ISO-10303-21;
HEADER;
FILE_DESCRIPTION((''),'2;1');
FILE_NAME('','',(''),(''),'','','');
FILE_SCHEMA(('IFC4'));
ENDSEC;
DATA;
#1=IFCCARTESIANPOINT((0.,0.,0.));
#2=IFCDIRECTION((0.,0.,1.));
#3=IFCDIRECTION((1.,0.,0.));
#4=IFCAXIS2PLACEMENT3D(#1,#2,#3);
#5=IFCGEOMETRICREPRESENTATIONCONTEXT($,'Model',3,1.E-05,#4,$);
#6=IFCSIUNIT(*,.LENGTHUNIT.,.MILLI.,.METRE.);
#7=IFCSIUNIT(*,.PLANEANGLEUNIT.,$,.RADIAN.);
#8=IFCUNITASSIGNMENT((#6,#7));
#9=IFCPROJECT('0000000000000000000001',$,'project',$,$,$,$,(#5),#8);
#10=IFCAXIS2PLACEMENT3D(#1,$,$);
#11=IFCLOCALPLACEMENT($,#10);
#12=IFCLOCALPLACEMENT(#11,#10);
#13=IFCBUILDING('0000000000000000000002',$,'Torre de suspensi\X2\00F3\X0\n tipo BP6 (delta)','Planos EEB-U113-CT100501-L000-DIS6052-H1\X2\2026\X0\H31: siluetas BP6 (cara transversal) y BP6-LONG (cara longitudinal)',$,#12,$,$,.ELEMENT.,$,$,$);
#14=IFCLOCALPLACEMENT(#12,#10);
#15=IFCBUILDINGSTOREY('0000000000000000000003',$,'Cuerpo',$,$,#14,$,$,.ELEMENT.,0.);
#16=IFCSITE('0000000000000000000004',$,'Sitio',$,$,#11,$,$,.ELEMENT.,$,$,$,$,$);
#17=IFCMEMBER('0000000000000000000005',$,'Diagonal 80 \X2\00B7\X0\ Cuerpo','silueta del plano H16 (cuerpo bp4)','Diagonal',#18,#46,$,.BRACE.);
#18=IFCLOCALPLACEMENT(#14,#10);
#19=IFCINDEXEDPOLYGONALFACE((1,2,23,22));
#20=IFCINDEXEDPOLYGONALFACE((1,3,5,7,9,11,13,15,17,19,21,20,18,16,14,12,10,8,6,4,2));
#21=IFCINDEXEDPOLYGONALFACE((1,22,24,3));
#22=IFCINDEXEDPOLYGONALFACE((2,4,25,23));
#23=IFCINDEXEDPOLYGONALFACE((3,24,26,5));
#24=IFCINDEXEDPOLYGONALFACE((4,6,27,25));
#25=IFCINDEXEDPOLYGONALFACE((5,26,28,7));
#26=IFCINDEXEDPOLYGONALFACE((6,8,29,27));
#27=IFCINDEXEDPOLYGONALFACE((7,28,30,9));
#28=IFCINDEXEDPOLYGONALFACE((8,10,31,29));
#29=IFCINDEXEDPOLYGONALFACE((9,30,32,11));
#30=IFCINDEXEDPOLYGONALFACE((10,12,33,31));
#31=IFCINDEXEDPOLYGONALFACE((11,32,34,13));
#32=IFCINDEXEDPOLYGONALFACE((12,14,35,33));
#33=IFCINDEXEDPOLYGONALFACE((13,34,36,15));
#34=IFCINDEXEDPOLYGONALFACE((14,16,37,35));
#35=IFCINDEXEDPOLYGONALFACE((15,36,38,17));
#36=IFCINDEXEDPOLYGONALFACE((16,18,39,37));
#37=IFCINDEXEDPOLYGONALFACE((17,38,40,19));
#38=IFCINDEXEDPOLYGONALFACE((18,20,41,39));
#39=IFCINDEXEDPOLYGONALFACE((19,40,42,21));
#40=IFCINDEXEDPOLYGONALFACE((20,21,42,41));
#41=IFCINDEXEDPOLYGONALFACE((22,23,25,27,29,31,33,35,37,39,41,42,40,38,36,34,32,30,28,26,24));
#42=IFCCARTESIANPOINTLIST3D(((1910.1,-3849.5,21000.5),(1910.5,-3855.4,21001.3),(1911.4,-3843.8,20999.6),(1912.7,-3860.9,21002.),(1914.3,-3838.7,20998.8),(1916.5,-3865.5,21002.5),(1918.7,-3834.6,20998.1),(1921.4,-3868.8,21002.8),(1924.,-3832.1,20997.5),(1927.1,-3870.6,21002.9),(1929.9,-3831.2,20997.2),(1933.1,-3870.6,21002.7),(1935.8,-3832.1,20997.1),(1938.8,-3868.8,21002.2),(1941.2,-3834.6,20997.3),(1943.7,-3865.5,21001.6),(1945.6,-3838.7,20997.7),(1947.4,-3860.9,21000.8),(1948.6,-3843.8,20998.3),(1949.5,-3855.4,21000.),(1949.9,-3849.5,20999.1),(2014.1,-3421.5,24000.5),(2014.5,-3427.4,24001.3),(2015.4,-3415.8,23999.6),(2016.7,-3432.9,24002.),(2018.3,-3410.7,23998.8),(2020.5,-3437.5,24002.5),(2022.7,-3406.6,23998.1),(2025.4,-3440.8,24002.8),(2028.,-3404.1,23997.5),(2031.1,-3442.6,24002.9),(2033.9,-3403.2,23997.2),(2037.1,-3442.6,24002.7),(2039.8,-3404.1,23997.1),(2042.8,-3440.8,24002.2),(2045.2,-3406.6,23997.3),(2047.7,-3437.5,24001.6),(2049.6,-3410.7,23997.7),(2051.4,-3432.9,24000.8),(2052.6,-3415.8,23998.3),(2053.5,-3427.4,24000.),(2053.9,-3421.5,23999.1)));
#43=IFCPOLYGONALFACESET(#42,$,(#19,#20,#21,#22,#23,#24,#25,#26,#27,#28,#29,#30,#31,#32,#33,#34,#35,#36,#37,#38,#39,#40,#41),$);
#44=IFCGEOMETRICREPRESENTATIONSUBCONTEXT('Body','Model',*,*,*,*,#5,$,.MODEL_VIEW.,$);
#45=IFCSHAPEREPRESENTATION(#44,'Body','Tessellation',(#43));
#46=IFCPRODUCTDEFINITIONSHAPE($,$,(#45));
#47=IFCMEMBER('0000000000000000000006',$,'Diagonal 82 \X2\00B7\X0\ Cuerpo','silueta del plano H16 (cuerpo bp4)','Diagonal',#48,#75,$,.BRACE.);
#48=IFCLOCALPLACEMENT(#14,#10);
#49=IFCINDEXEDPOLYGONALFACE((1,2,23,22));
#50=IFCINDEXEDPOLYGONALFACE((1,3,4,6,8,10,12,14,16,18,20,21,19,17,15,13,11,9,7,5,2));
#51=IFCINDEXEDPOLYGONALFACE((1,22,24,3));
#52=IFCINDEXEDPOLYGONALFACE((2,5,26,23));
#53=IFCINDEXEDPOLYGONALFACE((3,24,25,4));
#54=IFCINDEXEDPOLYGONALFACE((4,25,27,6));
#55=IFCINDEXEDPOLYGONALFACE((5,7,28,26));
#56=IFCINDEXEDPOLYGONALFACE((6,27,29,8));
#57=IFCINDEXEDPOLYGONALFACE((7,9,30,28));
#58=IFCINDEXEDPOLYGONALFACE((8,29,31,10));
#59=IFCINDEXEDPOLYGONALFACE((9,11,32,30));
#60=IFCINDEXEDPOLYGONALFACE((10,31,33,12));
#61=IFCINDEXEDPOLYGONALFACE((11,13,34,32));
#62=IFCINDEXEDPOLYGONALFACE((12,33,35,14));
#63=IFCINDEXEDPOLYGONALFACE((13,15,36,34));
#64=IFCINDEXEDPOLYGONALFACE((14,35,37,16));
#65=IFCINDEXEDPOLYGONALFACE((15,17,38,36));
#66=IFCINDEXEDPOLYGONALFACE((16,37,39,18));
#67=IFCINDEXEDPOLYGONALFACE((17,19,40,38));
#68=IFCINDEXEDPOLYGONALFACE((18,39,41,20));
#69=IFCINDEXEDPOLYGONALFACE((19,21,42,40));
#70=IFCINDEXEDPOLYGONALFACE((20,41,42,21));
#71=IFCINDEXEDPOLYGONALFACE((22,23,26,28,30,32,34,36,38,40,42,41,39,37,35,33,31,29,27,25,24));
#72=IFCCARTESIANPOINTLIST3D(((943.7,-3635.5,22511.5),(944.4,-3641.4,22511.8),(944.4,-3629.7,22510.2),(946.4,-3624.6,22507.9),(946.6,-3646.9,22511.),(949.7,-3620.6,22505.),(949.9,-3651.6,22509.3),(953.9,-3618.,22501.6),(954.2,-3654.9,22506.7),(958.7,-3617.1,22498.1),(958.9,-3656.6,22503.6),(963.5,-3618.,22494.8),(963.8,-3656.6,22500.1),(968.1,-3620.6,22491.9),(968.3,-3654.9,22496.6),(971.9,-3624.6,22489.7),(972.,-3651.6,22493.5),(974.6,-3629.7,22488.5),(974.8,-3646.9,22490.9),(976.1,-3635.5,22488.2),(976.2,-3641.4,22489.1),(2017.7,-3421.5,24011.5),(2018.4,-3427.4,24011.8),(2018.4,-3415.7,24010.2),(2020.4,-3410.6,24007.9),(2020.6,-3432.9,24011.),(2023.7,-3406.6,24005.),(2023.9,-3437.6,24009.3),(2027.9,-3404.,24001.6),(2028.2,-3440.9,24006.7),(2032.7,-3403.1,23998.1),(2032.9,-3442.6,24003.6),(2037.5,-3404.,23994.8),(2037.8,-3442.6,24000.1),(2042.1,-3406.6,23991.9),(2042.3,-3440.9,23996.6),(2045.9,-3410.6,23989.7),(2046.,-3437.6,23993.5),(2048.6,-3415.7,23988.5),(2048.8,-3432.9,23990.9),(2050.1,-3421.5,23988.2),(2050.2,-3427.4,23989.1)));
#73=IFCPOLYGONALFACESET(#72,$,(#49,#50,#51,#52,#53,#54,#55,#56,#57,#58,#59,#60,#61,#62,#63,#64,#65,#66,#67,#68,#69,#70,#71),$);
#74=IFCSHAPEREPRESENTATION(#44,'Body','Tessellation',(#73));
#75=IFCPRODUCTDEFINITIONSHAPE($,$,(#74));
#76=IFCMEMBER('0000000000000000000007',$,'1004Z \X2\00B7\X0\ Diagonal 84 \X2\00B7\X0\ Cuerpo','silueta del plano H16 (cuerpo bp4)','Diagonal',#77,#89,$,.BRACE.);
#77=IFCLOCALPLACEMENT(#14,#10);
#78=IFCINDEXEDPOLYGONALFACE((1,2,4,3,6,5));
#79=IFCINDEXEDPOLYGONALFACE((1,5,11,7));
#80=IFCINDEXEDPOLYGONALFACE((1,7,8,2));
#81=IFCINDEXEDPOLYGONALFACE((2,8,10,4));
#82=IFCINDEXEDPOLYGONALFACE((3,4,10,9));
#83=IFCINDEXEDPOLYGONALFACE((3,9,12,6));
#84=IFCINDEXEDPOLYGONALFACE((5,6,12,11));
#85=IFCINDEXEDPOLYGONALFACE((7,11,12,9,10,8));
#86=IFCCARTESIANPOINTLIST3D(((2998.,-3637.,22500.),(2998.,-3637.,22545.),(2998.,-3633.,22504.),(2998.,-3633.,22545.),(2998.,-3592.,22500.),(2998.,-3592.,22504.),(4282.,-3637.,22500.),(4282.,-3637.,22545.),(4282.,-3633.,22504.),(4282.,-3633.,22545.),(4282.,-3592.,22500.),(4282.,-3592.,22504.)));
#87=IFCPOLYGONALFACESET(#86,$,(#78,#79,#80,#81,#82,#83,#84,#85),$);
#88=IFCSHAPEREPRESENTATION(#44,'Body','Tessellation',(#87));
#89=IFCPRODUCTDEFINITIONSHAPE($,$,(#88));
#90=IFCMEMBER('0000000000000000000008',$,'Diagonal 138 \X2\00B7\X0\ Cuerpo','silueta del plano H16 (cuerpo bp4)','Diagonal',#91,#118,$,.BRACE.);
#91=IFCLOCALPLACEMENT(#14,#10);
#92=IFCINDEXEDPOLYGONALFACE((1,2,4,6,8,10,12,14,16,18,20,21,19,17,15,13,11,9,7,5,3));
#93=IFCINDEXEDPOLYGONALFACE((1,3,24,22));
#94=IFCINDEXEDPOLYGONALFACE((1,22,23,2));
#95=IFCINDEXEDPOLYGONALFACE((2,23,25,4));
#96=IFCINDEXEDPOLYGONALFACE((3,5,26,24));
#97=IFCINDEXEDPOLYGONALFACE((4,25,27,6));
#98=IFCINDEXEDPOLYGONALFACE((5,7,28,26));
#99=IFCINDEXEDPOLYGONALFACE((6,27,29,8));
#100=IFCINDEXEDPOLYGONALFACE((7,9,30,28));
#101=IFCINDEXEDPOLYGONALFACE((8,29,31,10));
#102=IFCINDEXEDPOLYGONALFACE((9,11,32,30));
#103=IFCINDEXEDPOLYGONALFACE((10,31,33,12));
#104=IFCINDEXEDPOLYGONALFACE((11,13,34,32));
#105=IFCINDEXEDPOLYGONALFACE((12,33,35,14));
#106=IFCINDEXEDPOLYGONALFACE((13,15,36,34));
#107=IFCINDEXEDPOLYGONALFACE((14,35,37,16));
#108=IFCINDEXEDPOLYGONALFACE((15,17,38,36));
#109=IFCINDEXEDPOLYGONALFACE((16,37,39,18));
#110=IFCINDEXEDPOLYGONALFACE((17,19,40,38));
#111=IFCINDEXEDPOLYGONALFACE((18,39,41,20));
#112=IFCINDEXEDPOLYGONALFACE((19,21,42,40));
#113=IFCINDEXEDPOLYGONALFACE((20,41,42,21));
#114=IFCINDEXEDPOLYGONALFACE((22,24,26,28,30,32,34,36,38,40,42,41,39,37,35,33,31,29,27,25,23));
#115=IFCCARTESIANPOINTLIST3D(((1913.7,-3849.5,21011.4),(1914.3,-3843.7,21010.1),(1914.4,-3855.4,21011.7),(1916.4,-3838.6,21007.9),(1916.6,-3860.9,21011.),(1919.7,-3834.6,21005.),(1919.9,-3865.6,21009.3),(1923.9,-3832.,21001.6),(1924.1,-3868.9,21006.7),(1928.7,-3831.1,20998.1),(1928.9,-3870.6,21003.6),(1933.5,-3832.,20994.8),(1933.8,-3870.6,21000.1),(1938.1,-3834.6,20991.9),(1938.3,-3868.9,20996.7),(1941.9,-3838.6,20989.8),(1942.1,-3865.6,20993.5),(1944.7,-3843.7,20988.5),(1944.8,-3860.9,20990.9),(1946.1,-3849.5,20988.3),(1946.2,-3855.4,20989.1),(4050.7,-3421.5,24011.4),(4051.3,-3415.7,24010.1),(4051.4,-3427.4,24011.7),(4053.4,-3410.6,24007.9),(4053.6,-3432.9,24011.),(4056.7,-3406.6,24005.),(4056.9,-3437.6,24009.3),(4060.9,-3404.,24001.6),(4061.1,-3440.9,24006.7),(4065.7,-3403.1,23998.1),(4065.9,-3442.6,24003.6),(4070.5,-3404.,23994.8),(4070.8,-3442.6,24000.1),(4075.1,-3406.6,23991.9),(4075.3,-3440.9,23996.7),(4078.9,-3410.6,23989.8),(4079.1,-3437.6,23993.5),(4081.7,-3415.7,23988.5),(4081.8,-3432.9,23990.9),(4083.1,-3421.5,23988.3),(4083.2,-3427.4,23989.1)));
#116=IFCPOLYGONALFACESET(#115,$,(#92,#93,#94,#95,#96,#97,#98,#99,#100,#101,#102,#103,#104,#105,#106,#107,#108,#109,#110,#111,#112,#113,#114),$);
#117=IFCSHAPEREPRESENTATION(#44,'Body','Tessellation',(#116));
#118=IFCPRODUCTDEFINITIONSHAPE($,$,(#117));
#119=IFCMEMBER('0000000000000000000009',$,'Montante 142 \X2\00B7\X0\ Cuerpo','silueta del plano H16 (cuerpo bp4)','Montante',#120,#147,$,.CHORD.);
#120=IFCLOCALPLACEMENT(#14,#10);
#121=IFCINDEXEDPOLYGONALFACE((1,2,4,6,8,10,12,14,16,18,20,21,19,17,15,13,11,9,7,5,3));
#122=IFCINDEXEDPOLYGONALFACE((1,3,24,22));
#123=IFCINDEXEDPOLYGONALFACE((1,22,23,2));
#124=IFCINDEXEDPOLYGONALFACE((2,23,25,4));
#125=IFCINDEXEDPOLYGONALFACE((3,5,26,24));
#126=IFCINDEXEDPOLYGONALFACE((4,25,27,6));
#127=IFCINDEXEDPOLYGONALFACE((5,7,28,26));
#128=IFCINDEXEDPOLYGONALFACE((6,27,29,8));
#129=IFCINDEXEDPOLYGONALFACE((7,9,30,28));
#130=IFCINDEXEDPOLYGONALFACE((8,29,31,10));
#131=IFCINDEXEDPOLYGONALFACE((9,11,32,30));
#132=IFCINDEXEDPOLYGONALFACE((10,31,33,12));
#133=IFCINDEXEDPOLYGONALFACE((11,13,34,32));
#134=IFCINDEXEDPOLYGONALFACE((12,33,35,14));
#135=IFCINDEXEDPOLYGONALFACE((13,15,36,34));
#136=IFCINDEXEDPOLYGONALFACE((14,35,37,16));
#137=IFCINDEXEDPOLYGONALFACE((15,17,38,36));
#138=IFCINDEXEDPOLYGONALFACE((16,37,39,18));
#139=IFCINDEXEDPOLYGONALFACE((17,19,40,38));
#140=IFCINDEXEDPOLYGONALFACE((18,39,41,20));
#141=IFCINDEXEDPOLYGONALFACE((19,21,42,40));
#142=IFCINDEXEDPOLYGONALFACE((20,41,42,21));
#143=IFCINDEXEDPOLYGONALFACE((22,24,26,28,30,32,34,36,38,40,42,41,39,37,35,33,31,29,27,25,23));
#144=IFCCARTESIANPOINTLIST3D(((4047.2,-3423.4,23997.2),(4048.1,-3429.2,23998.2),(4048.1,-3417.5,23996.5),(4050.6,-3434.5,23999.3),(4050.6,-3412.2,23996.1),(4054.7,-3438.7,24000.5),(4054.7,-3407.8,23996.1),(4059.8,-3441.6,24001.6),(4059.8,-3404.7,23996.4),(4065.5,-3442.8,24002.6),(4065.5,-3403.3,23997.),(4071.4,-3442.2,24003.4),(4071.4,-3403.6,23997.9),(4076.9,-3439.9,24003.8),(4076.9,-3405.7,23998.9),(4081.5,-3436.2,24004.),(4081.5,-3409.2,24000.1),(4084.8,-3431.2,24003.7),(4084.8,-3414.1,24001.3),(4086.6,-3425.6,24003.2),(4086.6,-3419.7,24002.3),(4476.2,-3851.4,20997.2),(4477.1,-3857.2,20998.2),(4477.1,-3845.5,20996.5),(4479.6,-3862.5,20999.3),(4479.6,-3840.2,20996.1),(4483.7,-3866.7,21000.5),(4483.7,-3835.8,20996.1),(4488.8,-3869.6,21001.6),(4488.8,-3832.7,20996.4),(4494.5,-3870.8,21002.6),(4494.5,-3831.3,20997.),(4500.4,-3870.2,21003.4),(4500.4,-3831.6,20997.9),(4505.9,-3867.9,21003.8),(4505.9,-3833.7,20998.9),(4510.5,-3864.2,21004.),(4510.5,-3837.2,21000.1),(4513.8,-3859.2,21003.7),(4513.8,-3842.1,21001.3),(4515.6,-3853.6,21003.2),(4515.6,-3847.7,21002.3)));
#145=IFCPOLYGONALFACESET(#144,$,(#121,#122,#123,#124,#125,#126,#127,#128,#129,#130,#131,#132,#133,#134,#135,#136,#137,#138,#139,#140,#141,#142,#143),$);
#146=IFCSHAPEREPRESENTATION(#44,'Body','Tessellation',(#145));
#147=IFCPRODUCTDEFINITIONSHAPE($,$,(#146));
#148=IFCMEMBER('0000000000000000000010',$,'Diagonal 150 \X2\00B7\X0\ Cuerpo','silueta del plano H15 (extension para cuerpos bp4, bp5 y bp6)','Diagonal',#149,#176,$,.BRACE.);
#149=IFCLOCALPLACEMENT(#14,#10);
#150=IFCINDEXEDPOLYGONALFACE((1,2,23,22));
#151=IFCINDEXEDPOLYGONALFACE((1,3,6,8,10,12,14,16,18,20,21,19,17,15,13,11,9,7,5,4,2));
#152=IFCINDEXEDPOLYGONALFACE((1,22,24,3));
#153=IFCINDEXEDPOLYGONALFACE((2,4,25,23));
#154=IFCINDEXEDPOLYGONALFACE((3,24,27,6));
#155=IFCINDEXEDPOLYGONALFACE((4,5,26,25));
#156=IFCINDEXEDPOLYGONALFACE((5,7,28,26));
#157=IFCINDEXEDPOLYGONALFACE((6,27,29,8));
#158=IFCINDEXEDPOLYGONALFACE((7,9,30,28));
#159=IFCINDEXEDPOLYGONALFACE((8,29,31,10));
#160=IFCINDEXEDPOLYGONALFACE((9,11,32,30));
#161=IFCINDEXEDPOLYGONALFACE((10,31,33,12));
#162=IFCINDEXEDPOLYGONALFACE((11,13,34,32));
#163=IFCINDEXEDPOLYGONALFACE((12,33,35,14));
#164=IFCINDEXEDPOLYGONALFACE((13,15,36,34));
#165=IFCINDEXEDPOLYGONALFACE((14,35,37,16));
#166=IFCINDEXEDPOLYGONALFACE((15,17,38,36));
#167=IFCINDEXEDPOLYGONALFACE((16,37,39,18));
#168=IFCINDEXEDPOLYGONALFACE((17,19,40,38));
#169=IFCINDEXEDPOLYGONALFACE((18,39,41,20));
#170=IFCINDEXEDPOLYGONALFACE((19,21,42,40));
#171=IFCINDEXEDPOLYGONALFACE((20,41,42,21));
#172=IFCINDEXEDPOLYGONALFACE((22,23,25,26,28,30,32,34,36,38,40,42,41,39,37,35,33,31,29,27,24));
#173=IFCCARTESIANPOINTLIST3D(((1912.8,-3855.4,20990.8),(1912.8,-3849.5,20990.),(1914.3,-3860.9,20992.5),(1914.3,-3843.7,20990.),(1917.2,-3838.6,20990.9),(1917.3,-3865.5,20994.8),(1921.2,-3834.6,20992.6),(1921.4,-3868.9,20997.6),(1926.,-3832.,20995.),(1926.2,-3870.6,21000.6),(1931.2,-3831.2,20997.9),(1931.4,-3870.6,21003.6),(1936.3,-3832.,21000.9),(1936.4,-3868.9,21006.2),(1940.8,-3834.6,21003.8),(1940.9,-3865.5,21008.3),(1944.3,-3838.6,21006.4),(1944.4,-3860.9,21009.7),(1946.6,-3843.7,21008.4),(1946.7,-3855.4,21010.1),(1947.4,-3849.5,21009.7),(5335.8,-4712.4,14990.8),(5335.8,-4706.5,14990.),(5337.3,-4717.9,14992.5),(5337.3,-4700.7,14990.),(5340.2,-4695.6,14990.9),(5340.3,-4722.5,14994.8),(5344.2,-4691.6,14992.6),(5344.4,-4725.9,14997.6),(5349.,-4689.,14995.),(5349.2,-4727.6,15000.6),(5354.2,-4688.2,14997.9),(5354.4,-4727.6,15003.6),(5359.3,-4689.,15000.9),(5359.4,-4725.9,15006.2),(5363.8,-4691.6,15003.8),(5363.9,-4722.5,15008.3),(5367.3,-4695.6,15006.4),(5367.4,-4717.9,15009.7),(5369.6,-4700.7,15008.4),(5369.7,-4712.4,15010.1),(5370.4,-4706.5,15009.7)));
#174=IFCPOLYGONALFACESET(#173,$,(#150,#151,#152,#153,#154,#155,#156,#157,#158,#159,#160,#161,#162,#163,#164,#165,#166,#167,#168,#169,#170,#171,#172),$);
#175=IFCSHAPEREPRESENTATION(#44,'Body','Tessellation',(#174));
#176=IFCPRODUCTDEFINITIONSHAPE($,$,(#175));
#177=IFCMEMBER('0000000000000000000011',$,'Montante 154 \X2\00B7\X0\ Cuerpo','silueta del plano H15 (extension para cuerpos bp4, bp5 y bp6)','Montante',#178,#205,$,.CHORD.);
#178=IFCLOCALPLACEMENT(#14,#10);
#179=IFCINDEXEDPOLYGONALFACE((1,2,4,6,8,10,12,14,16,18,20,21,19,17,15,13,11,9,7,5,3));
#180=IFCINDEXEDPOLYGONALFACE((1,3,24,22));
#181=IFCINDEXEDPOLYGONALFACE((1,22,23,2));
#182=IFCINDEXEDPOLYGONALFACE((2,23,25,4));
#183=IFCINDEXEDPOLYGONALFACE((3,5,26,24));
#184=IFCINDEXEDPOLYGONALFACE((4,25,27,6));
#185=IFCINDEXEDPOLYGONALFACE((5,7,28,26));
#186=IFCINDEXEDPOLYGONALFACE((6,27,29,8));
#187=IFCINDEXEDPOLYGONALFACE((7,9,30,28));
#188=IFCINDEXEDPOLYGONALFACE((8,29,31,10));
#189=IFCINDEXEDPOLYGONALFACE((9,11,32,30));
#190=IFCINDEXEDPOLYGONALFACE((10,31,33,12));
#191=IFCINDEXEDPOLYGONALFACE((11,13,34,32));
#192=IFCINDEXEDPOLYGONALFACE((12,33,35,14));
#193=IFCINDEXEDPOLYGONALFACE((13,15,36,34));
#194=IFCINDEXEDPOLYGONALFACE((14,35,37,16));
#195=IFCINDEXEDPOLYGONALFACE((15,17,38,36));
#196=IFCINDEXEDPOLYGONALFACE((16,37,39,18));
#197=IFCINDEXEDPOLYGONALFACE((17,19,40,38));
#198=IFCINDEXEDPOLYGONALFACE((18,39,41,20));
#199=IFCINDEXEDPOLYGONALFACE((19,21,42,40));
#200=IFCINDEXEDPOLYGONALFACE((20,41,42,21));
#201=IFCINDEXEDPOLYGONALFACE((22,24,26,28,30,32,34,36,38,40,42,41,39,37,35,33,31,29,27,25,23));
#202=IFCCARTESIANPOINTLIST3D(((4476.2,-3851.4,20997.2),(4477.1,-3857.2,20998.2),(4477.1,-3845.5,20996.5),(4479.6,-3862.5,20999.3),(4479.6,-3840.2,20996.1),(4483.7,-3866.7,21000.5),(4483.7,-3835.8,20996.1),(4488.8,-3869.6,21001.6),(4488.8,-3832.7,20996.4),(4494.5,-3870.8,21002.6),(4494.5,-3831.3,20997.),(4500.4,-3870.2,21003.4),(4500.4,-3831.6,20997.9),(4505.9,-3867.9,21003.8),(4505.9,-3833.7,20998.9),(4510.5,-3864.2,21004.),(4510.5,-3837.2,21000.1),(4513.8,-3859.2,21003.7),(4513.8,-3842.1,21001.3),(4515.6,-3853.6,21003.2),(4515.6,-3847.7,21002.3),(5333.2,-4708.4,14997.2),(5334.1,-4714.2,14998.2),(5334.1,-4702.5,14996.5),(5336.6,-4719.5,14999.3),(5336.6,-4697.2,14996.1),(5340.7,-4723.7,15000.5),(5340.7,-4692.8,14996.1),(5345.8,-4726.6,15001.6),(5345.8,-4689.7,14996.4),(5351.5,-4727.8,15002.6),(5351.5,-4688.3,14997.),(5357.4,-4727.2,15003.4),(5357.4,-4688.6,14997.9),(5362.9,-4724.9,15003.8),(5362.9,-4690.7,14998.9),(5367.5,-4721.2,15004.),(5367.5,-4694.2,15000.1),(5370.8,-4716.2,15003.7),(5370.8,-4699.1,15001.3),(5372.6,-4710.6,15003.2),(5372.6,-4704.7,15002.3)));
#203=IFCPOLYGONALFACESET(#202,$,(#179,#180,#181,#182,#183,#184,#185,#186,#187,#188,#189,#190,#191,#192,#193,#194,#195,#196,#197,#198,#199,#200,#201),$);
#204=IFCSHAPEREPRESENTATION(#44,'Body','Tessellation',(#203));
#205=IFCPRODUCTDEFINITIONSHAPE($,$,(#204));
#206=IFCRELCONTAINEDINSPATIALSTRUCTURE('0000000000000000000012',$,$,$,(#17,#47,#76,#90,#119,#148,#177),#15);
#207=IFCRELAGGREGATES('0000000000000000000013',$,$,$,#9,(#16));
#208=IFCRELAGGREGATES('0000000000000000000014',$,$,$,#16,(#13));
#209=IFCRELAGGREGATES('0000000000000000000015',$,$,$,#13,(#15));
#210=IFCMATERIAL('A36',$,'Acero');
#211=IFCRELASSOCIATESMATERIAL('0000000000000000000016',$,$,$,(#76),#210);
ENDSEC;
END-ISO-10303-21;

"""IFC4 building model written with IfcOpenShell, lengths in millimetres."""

from ifc_helpers import new_model, si_unit, frame, frame_2d, origin, origin_with_axes, place, context, subcontext, project, spatial, circle, l_section, extrude, material, element, save


model = new_model("IFC4")

# Units and contexts
model_context = context("Model", 3, precision=1e-05, world=origin_with_axes())
body_context = subcontext(model_context, "Body", "Model", "MODEL_VIEW")
ifc_project = project(units=[si_unit("LENGTHUNIT", "METRE", prefix="MILLI"), si_unit("PLANEANGLEUNIT", "RADIAN")], contexts=[model_context])

# Site, building, storey
site_placement = place(None, origin())
site = spatial("IfcSite", under=ifc_project, at=site_placement, Name="Sitio", CompositionType="ELEMENT")
building_placement = place(site_placement, origin())
building = spatial("IfcBuilding", under=site, at=building_placement, Name="Torre de suspensión tipo BP6 (delta)", Description="Planos EEB-U113-CT100501-L000-DIS6052-H1…H31: siluetas BP6 (cara transversal) y BP6-LONG (cara longitudinal)", CompositionType="ELEMENT")
storey_placement = place(building_placement, origin())
storey = spatial("IfcBuildingStorey", under=building, at=storey_placement, Name="Cuerpo", CompositionType="ELEMENT", Elevation=0.0)

# Members
member_1_placement = place(storey_placement, frame((1930.0, -3851.0, 21000.0), z_axis=(0.034299, 0.141153, 0.989393), x_axis=(-0.00489, 0.989988, -0.141069)))
element("IfcMember", 1, at=member_1_placement, inside=storey, Name="Diagonal 80 · Cuerpo", Description="silueta del plano H16 (cuerpo bp4)", ObjectType="Diagonal", PredefinedType="BRACE", context=body_context, shape_type="SweptSolid", body=[
    extrude(circle(Radius=20.0), None, (0.0, 0.0, 1.0), 3032.2),
])
member_2_placement = place(storey_placement, frame((2034.0, -3423.0, 24000.0), z_axis=(-0.578283, -0.115226, -0.807658), x_axis=(-0.06708, 0.993339, -0.093687)))
element("IfcMember", 2, at=member_2_placement, inside=storey, Name="Diagonal 82 · Cuerpo", Description="silueta del plano H16 (cuerpo bp4)", ObjectType="Diagonal", PredefinedType="BRACE", context=body_context, shape_type="SweptSolid", body=[
    extrude(circle(Radius=20.0), None, (0.0, 0.0, 1.0), 1857.2),
])
ifc_material = material(Name="A36", Category="Acero")
member_3_placement = place(storey_placement, frame((2998.0, -3637.0, 22500.0), z_axis=(1.0, 0.0, 0.0), x_axis=(0.0, 1.0, 0.0)))
element("IfcMember", 3, at=member_3_placement, inside=storey, material=ifc_material, Name="1004Z · Diagonal 84 · Cuerpo", Description="silueta del plano H16 (cuerpo bp4)", ObjectType="Diagonal", PredefinedType="BRACE", context=body_context, shape_type="SweptSolid", body=[
    extrude(l_section(Depth=45.0, Width=45.0, Thickness=4.0, at=frame_2d((22.5, 22.5))), None, (0.0, 0.0, 1.0), 1284.0),
])
member_4_placement = place(storey_placement, frame((4067.0, -3423.0, 24000.0), z_axis=(-0.576307, -0.115423, -0.809041), x_axis=(-0.066967, 0.993316, -0.09401)))
element("IfcMember", 4, at=member_4_placement, inside=storey, Name="Diagonal 138 · Cuerpo", Description="silueta del plano H16 (cuerpo bp4)", ObjectType="Diagonal", PredefinedType="BRACE", context=body_context, shape_type="SweptSolid", body=[
    extrude(circle(Radius=20.0), None, (0.0, 0.0, 1.0), 3708.1),
])
member_5_placement = place(storey_placement, frame((4067.0, -3423.0, 24000.0), z_axis=(0.140169, -0.139842, -0.980202), x_axis=(-0.990128, -0.019797, -0.138764)))
element("IfcMember", 5, at=member_5_placement, inside=storey, Name="Montante 142 · Cuerpo", Description="silueta del plano H16 (cuerpo bp4)", ObjectType="Montante", PredefinedType="CHORD", context=body_context, shape_type="SweptSolid", body=[
    extrude(circle(Radius=20.0), None, (0.0, 0.0, 1.0), 3060.6),
])
member_6_placement = place(storey_placement, frame((1930.0, -3851.0, 21000.0), z_axis=(0.491761, -0.12312, -0.861982), x_axis=(0.06101, 0.992392, -0.106941)))
element("IfcMember", 6, at=member_6_placement, inside=storey, Name="Diagonal 150 · Cuerpo", Description="silueta del plano H15 (extension para cuerpos bp4, bp5 y bp6)", ObjectType="Diagonal", PredefinedType="BRACE", context=body_context, shape_type="SweptSolid", body=[
    extrude(circle(Radius=20.0), None, (0.0, 0.0, 1.0), 6960.7),
])
member_7_placement = place(storey_placement, frame((4496.0, -3851.0, 21000.0), z_axis=(0.140006, -0.140006, -0.980202), x_axis=(-0.990151, -0.019797, -0.138599)))
element("IfcMember", 7, at=member_7_placement, inside=storey, Name="Montante 154 · Cuerpo", Description="silueta del plano H15 (extension para cuerpos bp4, bp5 y bp6)", ObjectType="Montante", PredefinedType="CHORD", context=body_context, shape_type="SweptSolid", body=[
    extrude(circle(Radius=20.0), None, (0.0, 0.0, 1.0), 6121.2),
])

save(model, "model.ifc")
